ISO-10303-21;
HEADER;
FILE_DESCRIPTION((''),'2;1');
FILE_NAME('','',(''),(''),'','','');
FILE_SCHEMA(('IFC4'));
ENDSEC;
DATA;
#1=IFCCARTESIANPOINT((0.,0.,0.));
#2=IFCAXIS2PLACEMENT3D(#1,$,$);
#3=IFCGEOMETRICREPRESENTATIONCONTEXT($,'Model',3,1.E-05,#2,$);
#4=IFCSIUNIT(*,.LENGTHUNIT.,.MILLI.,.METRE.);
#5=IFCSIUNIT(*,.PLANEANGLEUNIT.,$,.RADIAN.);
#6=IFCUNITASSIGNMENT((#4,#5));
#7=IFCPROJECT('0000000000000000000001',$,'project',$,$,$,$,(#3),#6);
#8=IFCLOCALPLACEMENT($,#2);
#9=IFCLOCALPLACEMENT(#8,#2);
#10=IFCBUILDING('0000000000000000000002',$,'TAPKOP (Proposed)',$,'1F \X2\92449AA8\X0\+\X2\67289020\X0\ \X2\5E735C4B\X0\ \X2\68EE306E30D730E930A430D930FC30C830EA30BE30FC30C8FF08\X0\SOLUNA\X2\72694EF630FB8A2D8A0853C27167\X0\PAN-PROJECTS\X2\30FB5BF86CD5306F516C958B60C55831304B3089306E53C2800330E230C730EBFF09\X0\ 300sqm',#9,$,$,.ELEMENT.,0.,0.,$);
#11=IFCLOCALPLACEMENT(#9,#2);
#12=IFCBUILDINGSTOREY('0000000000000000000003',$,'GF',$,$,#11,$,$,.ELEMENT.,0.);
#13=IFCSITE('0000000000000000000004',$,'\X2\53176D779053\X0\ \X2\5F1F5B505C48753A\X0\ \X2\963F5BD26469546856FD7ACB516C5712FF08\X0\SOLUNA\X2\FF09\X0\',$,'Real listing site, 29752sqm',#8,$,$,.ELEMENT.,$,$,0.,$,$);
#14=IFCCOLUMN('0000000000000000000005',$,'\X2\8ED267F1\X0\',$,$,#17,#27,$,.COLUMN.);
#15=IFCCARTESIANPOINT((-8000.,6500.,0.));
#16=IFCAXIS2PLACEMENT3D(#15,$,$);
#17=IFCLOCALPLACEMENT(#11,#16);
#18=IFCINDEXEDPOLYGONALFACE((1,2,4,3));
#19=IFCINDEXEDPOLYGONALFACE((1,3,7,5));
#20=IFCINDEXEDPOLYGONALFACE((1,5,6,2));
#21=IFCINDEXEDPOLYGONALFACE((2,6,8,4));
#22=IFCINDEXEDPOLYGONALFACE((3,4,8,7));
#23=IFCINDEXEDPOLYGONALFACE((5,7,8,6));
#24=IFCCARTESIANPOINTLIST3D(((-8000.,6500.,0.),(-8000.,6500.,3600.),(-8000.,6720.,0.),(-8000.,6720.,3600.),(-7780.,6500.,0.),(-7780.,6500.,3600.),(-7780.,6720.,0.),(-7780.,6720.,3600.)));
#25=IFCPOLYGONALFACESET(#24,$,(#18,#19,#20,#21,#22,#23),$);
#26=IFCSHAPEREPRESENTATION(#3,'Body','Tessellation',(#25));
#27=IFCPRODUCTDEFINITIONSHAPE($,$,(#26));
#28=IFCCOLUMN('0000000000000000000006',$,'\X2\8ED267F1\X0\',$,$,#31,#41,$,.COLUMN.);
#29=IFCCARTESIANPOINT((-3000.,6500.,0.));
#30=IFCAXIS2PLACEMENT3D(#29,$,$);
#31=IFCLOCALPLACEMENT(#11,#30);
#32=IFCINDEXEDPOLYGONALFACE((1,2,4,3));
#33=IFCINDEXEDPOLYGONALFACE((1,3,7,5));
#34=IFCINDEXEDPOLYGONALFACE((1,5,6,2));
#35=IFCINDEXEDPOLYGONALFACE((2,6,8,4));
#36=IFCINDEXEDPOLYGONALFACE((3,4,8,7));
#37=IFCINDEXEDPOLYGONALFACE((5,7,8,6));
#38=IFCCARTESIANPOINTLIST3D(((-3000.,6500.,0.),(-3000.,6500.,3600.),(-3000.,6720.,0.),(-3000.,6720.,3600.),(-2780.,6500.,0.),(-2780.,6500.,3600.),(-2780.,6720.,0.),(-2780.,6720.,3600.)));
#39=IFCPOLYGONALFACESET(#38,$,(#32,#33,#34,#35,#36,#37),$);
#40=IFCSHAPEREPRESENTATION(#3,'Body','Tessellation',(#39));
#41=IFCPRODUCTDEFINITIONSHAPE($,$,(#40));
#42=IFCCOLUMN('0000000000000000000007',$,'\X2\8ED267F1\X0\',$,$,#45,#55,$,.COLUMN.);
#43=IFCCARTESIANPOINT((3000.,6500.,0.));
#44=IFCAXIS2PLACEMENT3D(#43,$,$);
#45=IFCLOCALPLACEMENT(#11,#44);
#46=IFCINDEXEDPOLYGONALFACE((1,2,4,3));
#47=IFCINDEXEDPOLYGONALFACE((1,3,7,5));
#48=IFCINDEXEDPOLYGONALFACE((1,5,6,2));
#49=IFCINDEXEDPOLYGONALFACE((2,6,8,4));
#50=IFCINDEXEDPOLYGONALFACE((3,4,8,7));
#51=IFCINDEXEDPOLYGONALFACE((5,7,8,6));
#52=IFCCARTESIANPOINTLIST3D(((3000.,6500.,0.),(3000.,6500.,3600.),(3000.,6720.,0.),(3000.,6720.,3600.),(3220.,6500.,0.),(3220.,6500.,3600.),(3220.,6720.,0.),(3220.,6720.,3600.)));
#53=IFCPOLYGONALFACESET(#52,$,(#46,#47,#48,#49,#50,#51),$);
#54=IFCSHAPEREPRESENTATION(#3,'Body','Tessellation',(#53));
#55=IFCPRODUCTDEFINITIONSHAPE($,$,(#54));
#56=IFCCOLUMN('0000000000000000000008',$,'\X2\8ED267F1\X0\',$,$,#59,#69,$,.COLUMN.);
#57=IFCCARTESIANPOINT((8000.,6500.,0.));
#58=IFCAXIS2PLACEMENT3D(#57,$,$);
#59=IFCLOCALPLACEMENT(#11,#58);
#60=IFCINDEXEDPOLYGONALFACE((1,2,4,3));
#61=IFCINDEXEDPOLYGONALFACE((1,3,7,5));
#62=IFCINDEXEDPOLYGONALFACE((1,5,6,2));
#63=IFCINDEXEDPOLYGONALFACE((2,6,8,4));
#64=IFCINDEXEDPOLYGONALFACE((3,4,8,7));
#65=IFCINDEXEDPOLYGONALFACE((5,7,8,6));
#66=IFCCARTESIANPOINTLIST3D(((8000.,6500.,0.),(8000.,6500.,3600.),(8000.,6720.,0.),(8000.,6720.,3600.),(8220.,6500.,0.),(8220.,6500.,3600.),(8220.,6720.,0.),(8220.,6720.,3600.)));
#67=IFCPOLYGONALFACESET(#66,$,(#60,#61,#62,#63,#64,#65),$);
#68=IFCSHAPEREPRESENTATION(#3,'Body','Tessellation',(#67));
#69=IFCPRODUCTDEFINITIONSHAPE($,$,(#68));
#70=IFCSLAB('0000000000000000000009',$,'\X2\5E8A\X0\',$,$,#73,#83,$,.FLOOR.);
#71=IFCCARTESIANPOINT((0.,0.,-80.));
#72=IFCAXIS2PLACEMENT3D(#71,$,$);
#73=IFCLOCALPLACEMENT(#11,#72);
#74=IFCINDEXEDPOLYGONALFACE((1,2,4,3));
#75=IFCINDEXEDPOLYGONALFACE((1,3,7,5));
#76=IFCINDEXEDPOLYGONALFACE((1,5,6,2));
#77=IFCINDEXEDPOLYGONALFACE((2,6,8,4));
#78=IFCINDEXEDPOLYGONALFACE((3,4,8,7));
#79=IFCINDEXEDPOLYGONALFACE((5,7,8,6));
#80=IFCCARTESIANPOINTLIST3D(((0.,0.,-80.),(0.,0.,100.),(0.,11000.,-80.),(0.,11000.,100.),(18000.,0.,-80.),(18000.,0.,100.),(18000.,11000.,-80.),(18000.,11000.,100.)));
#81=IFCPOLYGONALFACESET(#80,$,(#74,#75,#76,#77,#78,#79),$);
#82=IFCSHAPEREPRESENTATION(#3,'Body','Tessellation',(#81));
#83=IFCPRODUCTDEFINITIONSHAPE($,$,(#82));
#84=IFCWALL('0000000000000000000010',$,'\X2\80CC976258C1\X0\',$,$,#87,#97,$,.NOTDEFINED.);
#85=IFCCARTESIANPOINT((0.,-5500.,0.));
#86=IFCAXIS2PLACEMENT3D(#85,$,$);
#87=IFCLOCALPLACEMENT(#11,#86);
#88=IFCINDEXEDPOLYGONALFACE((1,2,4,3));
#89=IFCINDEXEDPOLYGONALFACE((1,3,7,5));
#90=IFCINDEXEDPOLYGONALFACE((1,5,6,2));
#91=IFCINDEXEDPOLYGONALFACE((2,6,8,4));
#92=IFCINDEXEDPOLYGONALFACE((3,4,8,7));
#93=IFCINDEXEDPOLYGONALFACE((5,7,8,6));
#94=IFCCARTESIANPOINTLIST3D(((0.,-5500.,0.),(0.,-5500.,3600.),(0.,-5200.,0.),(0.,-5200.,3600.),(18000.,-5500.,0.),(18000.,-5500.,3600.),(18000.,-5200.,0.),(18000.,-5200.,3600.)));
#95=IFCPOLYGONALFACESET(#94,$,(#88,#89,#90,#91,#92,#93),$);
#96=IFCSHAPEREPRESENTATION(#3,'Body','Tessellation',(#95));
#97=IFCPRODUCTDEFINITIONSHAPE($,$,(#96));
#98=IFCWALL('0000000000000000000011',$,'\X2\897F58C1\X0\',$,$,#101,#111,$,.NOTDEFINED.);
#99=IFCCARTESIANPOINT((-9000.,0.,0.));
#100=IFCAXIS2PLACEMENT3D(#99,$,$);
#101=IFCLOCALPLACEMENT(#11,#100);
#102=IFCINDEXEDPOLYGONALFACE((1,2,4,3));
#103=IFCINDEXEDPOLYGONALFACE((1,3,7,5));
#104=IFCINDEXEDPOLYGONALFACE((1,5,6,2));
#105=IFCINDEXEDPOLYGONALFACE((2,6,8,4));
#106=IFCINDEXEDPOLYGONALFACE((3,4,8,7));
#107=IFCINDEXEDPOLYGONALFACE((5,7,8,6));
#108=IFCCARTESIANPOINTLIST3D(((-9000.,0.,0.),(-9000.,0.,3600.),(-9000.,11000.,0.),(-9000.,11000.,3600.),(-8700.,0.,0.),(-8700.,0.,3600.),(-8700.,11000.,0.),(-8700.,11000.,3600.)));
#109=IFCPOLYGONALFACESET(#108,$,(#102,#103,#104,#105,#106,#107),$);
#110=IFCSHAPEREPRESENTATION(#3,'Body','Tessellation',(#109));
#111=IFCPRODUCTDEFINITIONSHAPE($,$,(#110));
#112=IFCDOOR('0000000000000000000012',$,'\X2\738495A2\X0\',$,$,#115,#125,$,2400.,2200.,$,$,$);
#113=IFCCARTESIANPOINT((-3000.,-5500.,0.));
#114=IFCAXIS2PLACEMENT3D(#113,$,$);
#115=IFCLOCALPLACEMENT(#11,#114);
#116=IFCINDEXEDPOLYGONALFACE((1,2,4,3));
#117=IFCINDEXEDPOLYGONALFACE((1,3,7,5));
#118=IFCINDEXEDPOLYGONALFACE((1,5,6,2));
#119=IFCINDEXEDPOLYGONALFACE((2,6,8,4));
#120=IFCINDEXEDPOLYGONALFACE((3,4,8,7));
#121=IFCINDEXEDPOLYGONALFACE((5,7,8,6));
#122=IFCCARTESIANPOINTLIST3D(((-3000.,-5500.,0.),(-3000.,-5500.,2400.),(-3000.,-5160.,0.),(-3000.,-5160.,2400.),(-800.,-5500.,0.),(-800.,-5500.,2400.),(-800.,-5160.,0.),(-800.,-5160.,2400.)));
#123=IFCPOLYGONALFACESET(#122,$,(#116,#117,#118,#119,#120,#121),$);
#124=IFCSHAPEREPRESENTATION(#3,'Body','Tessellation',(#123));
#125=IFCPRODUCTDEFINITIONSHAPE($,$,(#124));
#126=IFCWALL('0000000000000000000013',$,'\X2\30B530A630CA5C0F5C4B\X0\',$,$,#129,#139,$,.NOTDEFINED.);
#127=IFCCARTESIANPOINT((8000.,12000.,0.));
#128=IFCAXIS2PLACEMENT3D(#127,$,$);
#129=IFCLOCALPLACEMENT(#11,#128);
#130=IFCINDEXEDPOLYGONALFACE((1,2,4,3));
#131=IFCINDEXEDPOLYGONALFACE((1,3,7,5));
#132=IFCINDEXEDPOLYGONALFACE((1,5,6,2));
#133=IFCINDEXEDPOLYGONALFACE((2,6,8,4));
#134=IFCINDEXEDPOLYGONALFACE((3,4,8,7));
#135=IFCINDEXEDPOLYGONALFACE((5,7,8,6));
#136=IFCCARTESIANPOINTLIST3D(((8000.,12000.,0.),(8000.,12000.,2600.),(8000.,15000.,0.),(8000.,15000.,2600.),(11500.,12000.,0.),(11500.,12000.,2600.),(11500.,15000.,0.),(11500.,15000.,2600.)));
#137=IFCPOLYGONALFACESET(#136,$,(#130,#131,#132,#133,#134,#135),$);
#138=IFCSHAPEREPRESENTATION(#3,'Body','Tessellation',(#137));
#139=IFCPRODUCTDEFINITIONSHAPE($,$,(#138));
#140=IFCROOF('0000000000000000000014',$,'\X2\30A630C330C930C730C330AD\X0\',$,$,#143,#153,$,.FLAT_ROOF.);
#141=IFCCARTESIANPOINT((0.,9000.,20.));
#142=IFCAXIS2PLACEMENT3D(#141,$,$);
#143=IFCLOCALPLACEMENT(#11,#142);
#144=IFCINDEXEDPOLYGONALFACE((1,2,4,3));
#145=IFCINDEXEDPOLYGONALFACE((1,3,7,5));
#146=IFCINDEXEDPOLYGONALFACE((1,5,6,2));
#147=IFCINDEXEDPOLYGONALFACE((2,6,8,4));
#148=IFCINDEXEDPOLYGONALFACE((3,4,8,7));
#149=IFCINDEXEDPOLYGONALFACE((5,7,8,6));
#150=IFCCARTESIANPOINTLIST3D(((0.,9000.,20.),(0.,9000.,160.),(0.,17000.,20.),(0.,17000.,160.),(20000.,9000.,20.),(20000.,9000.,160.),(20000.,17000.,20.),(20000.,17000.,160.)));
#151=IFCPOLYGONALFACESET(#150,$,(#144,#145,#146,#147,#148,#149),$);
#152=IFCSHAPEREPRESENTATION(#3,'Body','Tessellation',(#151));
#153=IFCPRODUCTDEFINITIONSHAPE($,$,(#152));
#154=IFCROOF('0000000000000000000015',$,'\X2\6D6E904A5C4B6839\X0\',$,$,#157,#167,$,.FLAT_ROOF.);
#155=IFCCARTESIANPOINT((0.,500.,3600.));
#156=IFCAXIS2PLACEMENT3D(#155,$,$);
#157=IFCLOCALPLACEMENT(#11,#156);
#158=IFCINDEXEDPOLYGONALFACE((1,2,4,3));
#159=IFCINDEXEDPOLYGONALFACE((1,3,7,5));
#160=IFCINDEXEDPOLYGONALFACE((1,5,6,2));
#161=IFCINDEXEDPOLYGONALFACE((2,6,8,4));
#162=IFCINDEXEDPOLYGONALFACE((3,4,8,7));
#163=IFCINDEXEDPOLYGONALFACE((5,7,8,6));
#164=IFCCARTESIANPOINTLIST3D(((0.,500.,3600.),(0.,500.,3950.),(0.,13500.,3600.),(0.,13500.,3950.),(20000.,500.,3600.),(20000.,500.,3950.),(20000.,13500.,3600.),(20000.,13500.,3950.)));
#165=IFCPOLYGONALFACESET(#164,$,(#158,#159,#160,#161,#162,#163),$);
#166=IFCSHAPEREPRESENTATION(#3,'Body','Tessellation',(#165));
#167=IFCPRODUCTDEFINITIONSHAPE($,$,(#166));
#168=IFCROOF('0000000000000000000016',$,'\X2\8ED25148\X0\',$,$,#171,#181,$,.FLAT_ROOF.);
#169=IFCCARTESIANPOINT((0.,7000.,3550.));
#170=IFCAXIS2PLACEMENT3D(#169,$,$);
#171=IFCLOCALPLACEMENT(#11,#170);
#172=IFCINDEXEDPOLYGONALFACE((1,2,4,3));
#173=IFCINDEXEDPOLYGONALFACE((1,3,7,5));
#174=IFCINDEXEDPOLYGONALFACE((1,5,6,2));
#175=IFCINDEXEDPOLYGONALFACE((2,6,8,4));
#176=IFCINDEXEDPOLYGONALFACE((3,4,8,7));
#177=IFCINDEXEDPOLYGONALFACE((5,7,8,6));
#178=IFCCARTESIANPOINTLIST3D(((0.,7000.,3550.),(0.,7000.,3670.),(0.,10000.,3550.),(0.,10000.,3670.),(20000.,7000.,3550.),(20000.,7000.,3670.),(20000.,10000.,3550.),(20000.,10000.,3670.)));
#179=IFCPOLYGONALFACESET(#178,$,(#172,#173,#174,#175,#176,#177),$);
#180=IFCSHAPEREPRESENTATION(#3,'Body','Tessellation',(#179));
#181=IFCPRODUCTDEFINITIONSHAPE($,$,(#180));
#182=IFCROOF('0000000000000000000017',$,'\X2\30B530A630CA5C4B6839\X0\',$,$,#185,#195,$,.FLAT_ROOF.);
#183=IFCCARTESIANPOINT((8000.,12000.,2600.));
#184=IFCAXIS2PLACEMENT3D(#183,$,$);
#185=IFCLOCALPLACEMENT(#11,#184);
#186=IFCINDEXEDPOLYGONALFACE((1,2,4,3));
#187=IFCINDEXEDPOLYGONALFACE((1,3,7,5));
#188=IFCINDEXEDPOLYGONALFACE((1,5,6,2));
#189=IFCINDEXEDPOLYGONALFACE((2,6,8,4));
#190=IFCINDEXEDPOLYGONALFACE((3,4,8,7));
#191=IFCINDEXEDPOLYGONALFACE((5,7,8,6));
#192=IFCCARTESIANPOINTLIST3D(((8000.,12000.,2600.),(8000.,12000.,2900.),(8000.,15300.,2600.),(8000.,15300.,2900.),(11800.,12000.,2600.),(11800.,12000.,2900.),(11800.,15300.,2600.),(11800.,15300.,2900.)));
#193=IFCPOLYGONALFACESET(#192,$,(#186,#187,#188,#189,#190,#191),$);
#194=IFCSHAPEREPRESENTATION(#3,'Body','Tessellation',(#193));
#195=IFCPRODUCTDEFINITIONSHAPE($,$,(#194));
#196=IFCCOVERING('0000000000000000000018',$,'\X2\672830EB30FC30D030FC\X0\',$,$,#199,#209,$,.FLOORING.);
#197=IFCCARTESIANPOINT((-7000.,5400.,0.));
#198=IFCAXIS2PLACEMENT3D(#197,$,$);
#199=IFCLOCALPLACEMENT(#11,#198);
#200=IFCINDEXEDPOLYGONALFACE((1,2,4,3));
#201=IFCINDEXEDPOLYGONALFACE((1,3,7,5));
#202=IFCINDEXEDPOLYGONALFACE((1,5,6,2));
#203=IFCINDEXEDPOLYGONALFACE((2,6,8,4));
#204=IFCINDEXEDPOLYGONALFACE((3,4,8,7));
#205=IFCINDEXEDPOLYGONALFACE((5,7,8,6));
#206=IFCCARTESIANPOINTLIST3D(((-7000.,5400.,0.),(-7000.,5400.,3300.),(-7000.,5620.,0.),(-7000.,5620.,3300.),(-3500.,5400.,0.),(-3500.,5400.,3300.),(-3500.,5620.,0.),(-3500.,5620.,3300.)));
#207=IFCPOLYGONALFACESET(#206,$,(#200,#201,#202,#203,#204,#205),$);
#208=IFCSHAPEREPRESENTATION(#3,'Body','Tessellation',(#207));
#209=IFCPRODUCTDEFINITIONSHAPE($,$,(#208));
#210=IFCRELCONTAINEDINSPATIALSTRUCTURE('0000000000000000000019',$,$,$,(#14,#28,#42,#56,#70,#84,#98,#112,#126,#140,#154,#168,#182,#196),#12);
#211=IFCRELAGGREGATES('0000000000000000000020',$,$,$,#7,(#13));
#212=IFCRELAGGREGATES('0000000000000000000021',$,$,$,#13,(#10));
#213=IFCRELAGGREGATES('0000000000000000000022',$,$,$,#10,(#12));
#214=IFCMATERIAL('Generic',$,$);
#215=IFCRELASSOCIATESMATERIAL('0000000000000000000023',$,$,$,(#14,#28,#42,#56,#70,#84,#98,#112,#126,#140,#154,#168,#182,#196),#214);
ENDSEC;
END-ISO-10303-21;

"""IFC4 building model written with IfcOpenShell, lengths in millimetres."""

from ifc_helpers import new_model, si_unit, frame, frame_2d, origin, place, context, project, spatial, rectangle, extrude, material, element, save


model = new_model("IFC4")

# Units and contexts
model_context = context("Model", 3, precision=1e-05, world=origin())
ifc_project = project(units=[si_unit("LENGTHUNIT", "METRE", prefix="MILLI"), si_unit("PLANEANGLEUNIT", "RADIAN")], contexts=[model_context])

# Site, building, storey
site_placement = place(None, origin())
site = spatial("IfcSite", under=ifc_project, at=site_placement, Name="北海道 弟子屈町 阿寒摩周国立公園（SOLUNA）", ObjectType="Real listing site, 29752sqm", CompositionType="ELEMENT", RefElevation=0.0)
building_placement = place(site_placement, origin())
building = spatial("IfcBuilding", under=site, at=building_placement, Name="TAPKOP (Proposed)", ObjectType="1F 鉄骨+木造 平屋 森のプライベートリゾート（SOLUNA物件・設計参照PAN-PROJECTS・寸法は公開情報からの参考モデル） 300sqm", CompositionType="ELEMENT", ElevationOfRefHeight=0.0, ElevationOfTerrain=0.0)
storey_placement = place(building_placement, origin())
storey = spatial("IfcBuildingStorey", under=building, at=storey_placement, Name="GF", CompositionType="ELEMENT", Elevation=0.0)

# Columns
ifc_material_1 = material(Name="Generic")
column_1_placement = place(storey_placement, frame((-8000.0, 6500.0, 0.0)))
element("IfcColumn", 1, at=column_1_placement, inside=storey, material=ifc_material_1, Name="軒柱", PredefinedType="COLUMN", context=model_context, shape_type="SweptSolid", body=[
    extrude(rectangle(XDim=220.0, YDim=220.0, at=frame_2d((110.0, 110.0))), frame((-8000.0, 6500.0, 0.0)), (0.0, 0.0, 1.0), 3600.0),
])
column_2_placement = place(storey_placement, frame((-3000.0, 6500.0, 0.0)))
element("IfcColumn", 2, at=column_2_placement, inside=storey, material=ifc_material_1, Name="軒柱", PredefinedType="COLUMN", context=model_context, shape_type="SweptSolid", body=[
    extrude(rectangle(XDim=220.0, YDim=220.0, at=frame_2d((110.0, 110.0))), frame((-3000.0, 6500.0, 0.0)), (0.0, 0.0, 1.0), 3600.0),
])
column_3_placement = place(storey_placement, frame((3000.0, 6500.0, 0.0)))
element("IfcColumn", 3, at=column_3_placement, inside=storey, material=ifc_material_1, Name="軒柱", PredefinedType="COLUMN", context=model_context, shape_type="SweptSolid", body=[
    extrude(rectangle(XDim=220.0, YDim=220.0, at=frame_2d((110.0, 110.0))), frame((3000.0, 6500.0, 0.0)), (0.0, 0.0, 1.0), 3600.0),
])
column_4_placement = place(storey_placement, frame((8000.0, 6500.0, 0.0)))
element("IfcColumn", 4, at=column_4_placement, inside=storey, material=ifc_material_1, Name="軒柱", PredefinedType="COLUMN", context=model_context, shape_type="SweptSolid", body=[
    extrude(rectangle(XDim=220.0, YDim=220.0, at=frame_2d((110.0, 110.0))), frame((8000.0, 6500.0, 0.0)), (0.0, 0.0, 1.0), 3600.0),
])

# Slab
slab_placement = place(storey_placement, frame((0.0, 0.0, -80.0)))
element("IfcSlab", 5, at=slab_placement, inside=storey, material=ifc_material_1, Name="床", PredefinedType="FLOOR", context=model_context, shape_type="SweptSolid", body=[
    extrude(rectangle(XDim=18000.0, YDim=11000.0, at=frame_2d((9000.0, 5500.0))), frame((0.0, 0.0, -80.0)), (0.0, 0.0, 1.0), 180.0),
])

# Walls
wall_1_placement = place(storey_placement, frame((0.0, -5500.0, 0.0)))
element("IfcWall", 6, at=wall_1_placement, inside=storey, material=ifc_material_1, Name="背面壁", PredefinedType="NOTDEFINED", context=model_context, shape_type="SweptSolid", body=[
    extrude(rectangle(XDim=18000.0, YDim=300.0, at=frame_2d((9000.0, 150.0))), frame((0.0, -5500.0, 0.0)), (0.0, 0.0, 1.0), 3600.0),
])
wall_2_placement = place(storey_placement, frame((-9000.0, 0.0, 0.0)))
element("IfcWall", 7, at=wall_2_placement, inside=storey, material=ifc_material_1, Name="西壁", PredefinedType="NOTDEFINED", context=model_context, shape_type="SweptSolid", body=[
    extrude(rectangle(XDim=300.0, YDim=11000.0, at=frame_2d((150.0, 5500.0))), frame((-9000.0, 0.0, 0.0)), (0.0, 0.0, 1.0), 3600.0),
])

# Door
door_placement = place(storey_placement, frame((-3000.0, -5500.0, 0.0)))
element("IfcDoor", 8, at=door_placement, inside=storey, material=ifc_material_1, Name="玄関", OverallHeight=2400.0, OverallWidth=2200.0, context=model_context, shape_type="SweptSolid", body=[
    extrude(rectangle(XDim=2200.0, YDim=340.0, at=frame_2d((1100.0, 170.0))), frame((-3000.0, -5500.0, 0.0)), (0.0, 0.0, 1.0), 2400.0),
])

# Wall
wall_3_placement = place(storey_placement, frame((8000.0, 12000.0, 0.0)))
element("IfcWall", 9, at=wall_3_placement, inside=storey, material=ifc_material_1, Name="サウナ小屋", PredefinedType="NOTDEFINED", context=model_context, shape_type="SweptSolid", body=[
    extrude(rectangle(XDim=3500.0, YDim=3000.0, at=frame_2d((1750.0, 1500.0))), frame((8000.0, 12000.0, 0.0)), (0.0, 0.0, 1.0), 2600.0),
])

# Roofs
roof_1_placement = place(storey_placement, frame((0.0, 9000.0, 20.0)))
element("IfcRoof", 10, at=roof_1_placement, inside=storey, material=ifc_material_1, Name="ウッドデッキ", PredefinedType="FLAT_ROOF", context=model_context, shape_type="SweptSolid", body=[
    extrude(rectangle(XDim=20000.0, YDim=8000.0, at=frame_2d((10000.0, 4000.0))), frame((0.0, 9000.0, 20.0)), (0.0, 0.0, 1.0), 140.0),
])
roof_2_placement = place(storey_placement, frame((0.0, 500.0, 3600.0)))
element("IfcRoof", 11, at=roof_2_placement, inside=storey, material=ifc_material_1, Name="浮遊屋根", PredefinedType="FLAT_ROOF", context=model_context, shape_type="SweptSolid", body=[
    extrude(rectangle(XDim=20000.0, YDim=13000.0, at=frame_2d((10000.0, 6500.0))), frame((0.0, 500.0, 3600.0)), (0.0, 0.0, 1.0), 350.0),
])
roof_3_placement = place(storey_placement, frame((0.0, 7000.0, 3550.0)))
element("IfcRoof", 12, at=roof_3_placement, inside=storey, material=ifc_material_1, Name="軒先", PredefinedType="FLAT_ROOF", context=model_context, shape_type="SweptSolid", body=[
    extrude(rectangle(XDim=20000.0, YDim=3000.0, at=frame_2d((10000.0, 1500.0))), frame((0.0, 7000.0, 3550.0)), (0.0, 0.0, 1.0), 120.0),
])
roof_4_placement = place(storey_placement, frame((8000.0, 12000.0, 2600.0)))
element("IfcRoof", 13, at=roof_4_placement, inside=storey, material=ifc_material_1, Name="サウナ屋根", PredefinedType="FLAT_ROOF", context=model_context, shape_type="SweptSolid", body=[
    extrude(rectangle(XDim=3800.0, YDim=3300.0, at=frame_2d((1900.0, 1650.0))), frame((8000.0, 12000.0, 2600.0)), (0.0, 0.0, 1.0), 300.0),
])

# Covering
covering_placement = place(storey_placement, frame((-7000.0, 5400.0, 0.0)))
element("IfcCovering", 14, at=covering_placement, inside=storey, material=ifc_material_1, Name="木ルーバー", PredefinedType="FLOORING", context=model_context, shape_type="SweptSolid", body=[
    extrude(rectangle(XDim=3500.0, YDim=220.0, at=frame_2d((1750.0, 110.0))), frame((-7000.0, 5400.0, 0.0)), (0.0, 0.0, 1.0), 3300.0),
])

save(model, "model.ifc")
